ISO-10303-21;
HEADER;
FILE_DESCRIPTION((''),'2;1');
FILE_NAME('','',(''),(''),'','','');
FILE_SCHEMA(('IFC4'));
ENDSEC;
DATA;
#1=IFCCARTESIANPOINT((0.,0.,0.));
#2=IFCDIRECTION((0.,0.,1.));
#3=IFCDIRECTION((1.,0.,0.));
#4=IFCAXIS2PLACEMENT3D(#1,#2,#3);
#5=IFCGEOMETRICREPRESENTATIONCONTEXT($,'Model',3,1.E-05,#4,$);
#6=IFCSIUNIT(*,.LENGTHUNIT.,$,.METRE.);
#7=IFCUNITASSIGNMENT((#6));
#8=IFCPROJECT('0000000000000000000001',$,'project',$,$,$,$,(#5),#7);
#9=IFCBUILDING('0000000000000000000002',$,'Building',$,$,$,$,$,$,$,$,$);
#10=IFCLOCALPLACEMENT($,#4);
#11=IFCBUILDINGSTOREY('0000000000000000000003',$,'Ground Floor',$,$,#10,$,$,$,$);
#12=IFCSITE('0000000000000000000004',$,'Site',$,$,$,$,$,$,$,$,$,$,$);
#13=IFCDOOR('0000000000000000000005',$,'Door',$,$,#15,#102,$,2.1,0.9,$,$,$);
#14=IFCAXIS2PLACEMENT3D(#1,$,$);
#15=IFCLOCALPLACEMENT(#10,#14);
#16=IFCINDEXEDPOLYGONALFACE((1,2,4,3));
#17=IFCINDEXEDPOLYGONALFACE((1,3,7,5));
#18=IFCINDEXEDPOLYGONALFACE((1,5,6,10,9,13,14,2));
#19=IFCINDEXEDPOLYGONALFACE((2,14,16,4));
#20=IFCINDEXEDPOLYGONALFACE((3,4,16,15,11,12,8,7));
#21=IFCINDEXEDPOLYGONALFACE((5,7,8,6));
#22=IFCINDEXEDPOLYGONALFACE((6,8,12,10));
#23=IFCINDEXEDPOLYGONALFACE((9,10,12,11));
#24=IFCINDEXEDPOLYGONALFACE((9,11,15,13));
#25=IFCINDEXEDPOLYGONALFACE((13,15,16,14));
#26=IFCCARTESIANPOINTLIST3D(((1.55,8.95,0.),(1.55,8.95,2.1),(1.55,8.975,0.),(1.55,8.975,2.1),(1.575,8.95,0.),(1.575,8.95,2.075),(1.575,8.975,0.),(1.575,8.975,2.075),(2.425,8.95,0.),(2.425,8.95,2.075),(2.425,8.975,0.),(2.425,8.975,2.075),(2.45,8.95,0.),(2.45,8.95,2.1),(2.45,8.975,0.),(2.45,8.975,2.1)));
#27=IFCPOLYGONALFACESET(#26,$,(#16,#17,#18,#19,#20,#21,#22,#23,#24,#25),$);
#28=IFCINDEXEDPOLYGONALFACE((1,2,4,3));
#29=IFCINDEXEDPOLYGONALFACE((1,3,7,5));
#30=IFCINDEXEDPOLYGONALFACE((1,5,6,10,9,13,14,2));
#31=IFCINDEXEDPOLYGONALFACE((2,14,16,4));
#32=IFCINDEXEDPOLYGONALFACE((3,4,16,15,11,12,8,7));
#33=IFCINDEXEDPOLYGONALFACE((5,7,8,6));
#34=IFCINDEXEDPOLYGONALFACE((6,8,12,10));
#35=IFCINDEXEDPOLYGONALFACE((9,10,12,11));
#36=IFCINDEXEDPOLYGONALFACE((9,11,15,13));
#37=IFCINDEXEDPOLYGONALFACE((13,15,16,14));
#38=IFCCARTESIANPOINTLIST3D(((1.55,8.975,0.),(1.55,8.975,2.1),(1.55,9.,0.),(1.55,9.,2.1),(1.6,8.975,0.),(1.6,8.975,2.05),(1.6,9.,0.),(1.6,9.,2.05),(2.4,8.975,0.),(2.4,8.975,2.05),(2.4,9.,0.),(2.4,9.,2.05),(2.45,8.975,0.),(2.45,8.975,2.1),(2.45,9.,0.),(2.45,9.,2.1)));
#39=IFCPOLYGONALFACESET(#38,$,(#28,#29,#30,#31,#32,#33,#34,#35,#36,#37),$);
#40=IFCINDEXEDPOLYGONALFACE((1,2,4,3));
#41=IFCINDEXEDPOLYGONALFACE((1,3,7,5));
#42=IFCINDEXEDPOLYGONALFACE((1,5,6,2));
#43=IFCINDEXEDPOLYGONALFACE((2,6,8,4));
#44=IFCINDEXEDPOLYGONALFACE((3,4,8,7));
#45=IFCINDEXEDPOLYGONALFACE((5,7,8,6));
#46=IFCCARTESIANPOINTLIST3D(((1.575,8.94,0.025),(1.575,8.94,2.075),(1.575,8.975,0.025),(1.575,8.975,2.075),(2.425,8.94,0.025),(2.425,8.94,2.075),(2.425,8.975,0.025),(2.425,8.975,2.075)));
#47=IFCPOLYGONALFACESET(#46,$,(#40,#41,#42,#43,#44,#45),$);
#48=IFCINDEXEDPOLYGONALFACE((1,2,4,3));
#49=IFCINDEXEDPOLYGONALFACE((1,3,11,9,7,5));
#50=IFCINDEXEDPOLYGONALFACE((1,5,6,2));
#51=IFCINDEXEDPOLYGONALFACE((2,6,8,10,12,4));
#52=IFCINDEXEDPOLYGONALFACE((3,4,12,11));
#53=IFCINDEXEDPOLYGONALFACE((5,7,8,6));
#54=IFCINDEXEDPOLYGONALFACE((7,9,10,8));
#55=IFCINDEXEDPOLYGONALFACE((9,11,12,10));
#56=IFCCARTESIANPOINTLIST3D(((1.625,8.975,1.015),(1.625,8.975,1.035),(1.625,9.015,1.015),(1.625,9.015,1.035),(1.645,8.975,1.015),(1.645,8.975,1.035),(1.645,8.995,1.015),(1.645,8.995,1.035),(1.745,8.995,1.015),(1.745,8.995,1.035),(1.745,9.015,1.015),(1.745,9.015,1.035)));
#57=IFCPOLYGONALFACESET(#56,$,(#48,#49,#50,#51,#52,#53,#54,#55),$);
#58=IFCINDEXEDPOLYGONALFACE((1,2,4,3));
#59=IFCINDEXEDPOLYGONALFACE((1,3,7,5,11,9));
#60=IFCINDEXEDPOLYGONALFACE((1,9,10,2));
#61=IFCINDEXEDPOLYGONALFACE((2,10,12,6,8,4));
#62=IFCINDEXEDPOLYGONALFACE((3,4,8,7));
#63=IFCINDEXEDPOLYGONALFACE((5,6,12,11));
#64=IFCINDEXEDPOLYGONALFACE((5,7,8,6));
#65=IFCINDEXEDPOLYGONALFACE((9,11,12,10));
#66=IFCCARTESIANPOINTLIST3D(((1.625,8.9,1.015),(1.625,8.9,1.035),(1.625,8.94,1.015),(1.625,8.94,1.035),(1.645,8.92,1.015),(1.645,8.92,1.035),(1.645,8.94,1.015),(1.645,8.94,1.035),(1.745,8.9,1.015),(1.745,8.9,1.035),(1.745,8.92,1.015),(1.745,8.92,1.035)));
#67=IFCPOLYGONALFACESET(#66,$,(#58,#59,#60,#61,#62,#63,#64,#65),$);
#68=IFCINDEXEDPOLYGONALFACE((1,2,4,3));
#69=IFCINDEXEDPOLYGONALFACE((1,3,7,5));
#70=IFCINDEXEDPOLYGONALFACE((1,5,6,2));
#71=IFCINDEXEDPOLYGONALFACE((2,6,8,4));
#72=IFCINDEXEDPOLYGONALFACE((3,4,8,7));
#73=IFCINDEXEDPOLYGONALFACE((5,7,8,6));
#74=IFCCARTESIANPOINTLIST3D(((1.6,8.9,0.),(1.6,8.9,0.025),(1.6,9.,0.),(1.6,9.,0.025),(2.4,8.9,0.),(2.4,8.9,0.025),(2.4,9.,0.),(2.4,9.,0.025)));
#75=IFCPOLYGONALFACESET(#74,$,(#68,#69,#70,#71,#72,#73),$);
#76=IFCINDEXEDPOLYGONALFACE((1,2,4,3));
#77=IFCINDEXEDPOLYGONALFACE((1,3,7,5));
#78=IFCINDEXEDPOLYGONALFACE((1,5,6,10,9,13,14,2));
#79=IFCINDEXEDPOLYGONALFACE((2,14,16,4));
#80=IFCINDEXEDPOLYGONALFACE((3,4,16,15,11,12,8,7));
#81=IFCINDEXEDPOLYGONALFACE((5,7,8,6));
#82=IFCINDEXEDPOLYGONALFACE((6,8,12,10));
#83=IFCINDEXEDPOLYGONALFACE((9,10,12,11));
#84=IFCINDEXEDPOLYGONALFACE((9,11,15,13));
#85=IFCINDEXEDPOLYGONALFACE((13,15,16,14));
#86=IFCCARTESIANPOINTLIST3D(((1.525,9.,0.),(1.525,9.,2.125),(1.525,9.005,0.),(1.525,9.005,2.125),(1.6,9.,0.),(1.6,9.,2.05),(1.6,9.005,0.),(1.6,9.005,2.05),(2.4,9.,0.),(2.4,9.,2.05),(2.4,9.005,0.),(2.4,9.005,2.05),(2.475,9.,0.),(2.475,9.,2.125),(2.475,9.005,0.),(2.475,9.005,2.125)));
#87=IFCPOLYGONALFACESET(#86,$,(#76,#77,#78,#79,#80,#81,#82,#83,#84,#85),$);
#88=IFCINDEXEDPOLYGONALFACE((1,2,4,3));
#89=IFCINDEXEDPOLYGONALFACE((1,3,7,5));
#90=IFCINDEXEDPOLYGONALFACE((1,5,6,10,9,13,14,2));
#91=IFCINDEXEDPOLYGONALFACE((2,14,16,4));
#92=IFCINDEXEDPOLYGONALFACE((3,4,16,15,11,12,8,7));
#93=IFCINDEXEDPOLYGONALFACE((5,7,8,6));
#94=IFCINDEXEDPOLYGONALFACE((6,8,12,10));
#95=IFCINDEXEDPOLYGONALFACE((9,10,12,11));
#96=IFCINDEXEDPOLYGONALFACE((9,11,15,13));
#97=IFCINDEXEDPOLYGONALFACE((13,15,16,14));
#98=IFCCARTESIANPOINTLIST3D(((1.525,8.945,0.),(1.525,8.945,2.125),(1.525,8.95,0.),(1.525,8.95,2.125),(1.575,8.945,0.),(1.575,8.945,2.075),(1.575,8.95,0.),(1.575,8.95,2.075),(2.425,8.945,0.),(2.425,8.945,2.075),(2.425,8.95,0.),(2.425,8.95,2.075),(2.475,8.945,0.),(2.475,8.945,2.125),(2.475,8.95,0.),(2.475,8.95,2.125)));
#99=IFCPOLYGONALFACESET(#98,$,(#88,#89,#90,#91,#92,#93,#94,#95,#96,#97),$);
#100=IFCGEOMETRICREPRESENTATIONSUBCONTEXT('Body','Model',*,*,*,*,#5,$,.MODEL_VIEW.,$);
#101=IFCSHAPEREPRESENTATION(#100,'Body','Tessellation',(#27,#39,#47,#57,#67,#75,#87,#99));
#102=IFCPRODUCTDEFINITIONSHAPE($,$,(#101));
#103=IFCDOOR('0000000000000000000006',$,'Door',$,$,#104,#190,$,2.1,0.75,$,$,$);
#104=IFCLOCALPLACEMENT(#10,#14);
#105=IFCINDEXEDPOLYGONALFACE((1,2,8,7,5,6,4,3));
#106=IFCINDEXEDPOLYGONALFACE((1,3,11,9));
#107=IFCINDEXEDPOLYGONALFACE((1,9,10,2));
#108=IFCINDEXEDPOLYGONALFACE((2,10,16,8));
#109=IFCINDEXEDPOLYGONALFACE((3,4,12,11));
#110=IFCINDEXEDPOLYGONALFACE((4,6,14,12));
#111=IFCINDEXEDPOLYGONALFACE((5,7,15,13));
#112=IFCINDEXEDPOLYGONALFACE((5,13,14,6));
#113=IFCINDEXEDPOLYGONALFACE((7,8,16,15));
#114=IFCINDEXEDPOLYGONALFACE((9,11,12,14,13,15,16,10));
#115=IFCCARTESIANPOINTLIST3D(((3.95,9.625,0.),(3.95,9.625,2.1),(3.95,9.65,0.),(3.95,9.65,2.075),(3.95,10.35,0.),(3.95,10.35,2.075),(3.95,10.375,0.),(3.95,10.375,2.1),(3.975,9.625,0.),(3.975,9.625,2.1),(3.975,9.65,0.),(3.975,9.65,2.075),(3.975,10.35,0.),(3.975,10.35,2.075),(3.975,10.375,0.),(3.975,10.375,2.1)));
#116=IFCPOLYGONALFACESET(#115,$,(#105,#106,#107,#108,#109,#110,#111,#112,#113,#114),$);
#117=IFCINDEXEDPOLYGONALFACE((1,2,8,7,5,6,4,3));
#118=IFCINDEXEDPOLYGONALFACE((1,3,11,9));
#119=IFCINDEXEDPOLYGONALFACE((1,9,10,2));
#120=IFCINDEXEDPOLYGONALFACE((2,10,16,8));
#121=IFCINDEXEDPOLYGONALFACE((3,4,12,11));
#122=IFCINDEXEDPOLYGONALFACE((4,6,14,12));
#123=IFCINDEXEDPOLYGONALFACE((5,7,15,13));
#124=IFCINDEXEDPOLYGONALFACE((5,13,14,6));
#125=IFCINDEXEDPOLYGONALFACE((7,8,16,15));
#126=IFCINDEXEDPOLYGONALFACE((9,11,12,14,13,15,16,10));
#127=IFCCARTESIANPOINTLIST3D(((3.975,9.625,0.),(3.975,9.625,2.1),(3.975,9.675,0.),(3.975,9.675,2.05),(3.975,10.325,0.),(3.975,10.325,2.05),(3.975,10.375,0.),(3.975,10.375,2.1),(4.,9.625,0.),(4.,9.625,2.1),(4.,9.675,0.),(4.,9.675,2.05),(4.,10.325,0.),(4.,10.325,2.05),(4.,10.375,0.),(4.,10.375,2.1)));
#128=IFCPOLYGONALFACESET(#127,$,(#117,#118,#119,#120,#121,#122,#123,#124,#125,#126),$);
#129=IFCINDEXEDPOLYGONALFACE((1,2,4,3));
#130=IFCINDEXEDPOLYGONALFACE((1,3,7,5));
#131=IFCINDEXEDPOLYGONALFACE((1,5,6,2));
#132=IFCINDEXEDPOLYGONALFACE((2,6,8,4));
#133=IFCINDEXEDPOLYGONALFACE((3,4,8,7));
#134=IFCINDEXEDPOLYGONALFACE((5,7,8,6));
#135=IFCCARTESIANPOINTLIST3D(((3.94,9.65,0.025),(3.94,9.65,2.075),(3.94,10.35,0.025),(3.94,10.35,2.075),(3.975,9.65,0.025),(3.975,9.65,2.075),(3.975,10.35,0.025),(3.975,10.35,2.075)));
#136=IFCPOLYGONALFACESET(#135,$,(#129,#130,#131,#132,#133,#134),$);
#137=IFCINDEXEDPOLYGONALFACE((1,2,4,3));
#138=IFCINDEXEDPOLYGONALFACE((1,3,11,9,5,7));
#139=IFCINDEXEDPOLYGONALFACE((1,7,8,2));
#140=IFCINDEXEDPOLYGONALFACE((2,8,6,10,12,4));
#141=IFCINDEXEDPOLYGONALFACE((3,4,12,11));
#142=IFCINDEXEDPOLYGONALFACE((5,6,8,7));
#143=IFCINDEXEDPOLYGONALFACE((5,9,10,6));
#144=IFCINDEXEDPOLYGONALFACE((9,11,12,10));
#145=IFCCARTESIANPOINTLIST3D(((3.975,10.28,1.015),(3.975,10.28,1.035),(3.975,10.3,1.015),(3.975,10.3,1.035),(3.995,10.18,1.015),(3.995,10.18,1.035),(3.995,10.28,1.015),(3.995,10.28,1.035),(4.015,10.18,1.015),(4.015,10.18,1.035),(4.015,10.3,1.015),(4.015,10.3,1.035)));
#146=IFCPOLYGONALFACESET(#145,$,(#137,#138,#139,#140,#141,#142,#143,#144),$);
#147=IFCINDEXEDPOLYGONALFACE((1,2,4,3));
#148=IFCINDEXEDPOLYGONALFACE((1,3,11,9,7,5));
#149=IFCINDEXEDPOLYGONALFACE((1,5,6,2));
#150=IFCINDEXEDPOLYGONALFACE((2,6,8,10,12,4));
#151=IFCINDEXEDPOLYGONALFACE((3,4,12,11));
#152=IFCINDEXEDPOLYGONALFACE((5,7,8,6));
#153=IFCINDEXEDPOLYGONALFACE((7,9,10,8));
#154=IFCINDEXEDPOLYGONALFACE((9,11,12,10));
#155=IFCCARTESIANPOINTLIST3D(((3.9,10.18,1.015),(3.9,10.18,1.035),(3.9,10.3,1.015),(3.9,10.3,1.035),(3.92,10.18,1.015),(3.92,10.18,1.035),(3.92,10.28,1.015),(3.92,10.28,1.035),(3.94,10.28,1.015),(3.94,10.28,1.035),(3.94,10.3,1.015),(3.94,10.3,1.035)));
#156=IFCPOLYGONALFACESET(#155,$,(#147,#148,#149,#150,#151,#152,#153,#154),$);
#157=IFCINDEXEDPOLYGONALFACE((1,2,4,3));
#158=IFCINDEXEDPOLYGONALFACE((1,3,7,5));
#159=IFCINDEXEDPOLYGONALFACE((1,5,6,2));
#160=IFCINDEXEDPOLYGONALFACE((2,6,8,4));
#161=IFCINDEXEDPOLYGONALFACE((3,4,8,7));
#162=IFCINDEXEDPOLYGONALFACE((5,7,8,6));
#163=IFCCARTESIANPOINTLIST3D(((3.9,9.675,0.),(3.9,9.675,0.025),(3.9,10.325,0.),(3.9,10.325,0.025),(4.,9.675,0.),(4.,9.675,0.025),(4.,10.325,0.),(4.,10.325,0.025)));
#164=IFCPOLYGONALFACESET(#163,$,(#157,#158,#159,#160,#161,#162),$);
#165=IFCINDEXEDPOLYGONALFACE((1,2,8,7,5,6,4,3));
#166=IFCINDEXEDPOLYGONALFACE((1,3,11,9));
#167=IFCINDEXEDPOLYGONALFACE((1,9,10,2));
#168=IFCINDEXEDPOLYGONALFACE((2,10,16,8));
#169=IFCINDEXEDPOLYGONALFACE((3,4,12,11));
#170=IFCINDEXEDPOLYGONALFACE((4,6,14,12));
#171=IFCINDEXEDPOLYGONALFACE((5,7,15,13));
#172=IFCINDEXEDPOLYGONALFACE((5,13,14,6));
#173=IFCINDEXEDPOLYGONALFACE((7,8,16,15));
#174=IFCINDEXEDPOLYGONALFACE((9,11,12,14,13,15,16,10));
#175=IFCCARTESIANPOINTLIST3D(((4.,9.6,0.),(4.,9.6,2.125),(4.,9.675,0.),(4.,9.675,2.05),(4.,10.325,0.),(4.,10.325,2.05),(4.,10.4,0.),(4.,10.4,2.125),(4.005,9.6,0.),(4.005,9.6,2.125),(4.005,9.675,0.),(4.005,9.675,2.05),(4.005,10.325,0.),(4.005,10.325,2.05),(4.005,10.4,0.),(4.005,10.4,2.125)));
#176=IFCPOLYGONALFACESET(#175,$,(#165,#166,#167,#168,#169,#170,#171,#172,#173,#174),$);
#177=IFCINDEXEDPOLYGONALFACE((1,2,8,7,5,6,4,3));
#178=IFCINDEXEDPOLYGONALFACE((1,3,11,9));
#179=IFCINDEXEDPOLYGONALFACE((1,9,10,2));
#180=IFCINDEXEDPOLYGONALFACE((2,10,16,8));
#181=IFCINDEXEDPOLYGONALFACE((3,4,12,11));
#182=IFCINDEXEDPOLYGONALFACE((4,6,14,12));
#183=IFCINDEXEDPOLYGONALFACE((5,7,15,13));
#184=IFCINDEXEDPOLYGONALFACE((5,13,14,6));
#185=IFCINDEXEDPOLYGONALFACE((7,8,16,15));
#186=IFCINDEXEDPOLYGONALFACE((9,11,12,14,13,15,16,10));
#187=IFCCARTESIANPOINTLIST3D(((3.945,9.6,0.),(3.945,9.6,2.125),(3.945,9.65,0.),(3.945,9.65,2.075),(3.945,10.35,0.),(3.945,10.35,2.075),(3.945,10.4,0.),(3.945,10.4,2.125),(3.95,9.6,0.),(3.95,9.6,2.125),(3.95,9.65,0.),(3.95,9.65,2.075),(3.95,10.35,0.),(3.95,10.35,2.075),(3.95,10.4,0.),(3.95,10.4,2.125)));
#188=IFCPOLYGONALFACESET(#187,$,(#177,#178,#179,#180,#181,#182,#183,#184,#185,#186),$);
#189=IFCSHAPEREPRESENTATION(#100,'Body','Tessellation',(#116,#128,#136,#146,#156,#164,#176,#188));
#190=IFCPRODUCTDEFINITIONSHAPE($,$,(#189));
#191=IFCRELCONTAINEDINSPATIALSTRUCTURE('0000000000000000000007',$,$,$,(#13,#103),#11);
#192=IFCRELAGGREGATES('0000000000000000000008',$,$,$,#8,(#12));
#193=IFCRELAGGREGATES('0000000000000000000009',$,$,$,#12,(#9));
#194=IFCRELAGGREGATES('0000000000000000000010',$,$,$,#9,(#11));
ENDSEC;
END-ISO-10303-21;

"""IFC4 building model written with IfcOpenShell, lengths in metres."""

from ifc_helpers import new_model, si_unit, frame, origin_with_axes, place, context, subcontext, project, spatial, line, indexed_curve, outline, extrude, element, save


model = new_model("IFC4")

# Units and contexts
model_context = context("Model", 3, precision=1e-05, world=origin_with_axes())
body_context = subcontext(model_context, "Body", "Model", "MODEL_VIEW")
ifc_project = project(units=[si_unit("LENGTHUNIT", "METRE")], contexts=[model_context])

# Site, building, storey
site = spatial("IfcSite", under=ifc_project, Name="Site")
building = spatial("IfcBuilding", under=site, Name="Building")
storey_placement = place(None, origin_with_axes())
storey = spatial("IfcBuildingStorey", under=building, at=storey_placement, Name="Ground Floor")

# Doors
door_1_placement = place(storey_placement, frame((2.45, 9.0, 0.0), z_axis=(0.0, 0.0, 1.0), x_axis=(-1.0, 0.0, 0.0)))
element("IfcDoor", 1, at=door_1_placement, inside=storey, Name="Door", OverallHeight=2.1, OverallWidth=0.9, context=body_context, shape_type="SweptSolid", body=[
    extrude(outline(indexed_curve([(0.0, 0.0), (0.0, 2.1), (0.9, 2.1), (0.9, 0.0), (0.875, 0.0), (0.875, 2.075), (0.025, 2.075), (0.025, 0.0)], segments=[line(1, 2, 3, 4, 5, 6, 7, 8, 1)])), frame((0.0, 0.025, 0.0), z_axis=(0.0, -1.0, 0.0), x_axis=(1.0, 0.0, 0.0)), (0.0, 0.0, -1.0), 0.025),
    extrude(outline(indexed_curve([(0.0, 0.0), (0.0, 2.1), (0.9, 2.1), (0.9, 0.0), (0.85, 0.0), (0.85, 2.05), (0.05, 2.05), (0.05, 0.0)], segments=[line(1, 2, 3, 4, 5, 6, 7, 8, 1)])), frame((0.0, 0.0, 0.0), z_axis=(0.0, -1.0, 0.0), x_axis=(1.0, 0.0, 0.0)), (0.0, 0.0, -1.0), 0.025),
    extrude(outline(indexed_curve([(0.0, 0.0), (0.85, 0.0), (0.85, 0.035), (0.0, 0.035)], segments=[line(1, 2, 3, 4, 1)])), frame((0.025, 0.025, 0.025), z_axis=(0.0, 0.0, 1.0), x_axis=(1.0, 0.0, 0.0)), (0.0, 0.0, 1.0), 2.05),
    extrude(outline(indexed_curve([(0.0, 0.0), (0.0, -0.04), (-0.12, -0.04), (-0.12, -0.02), (-0.02, -0.02), (-0.02, 0.0)], segments=[line(1, 2, 3, 4, 5, 6, 1)])), frame((0.825, 0.025, 1.015), z_axis=(0.0, 0.0, 1.0), x_axis=(1.0, 0.0, 0.0)), (0.0, 0.0, 1.0), 0.02),
    extrude(outline(indexed_curve([(0.0, 0.0), (0.0, 0.04), (-0.12, 0.04), (-0.12, 0.02), (-0.02, 0.02), (-0.02, 0.0)], segments=[line(1, 2, 3, 4, 5, 6, 1)])), frame((0.825, 0.06, 1.015), z_axis=(0.0, 0.0, 1.0), x_axis=(1.0, 0.0, 0.0)), (0.0, 0.0, 1.0), 0.02),
    extrude(outline(indexed_curve([(0.0, 0.0), (0.8, 0.0), (0.8, 0.1), (0.0, 0.1)], segments=[line(1, 2, 3, 4, 1)])), frame((0.05, 0.0, 0.0), z_axis=(0.0, 0.0, 1.0), x_axis=(1.0, 0.0, 0.0)), (0.0, 0.0, 1.0), 0.025),
    extrude(outline(indexed_curve([(0.0, 0.0), (0.0, 2.125), (0.95, 2.125), (0.95, 0.0), (0.875, 0.0), (0.875, 2.05), (0.075, 2.05), (0.075, 0.0)], segments=[line(1, 2, 3, 4, 5, 6, 7, 8, 1)])), frame((-0.025, -0.005, 0.0), z_axis=(0.0, -1.0, 0.0), x_axis=(1.0, 0.0, 0.0)), (0.0, 0.0, -1.0), 0.005),
    extrude(outline(indexed_curve([(0.0, 0.0), (0.0, 2.125), (0.95, 2.125), (0.95, 0.0), (0.9, 0.0), (0.9, 2.075), (0.05, 2.075), (0.05, 0.0)], segments=[line(1, 2, 3, 4, 5, 6, 7, 8, 1)])), frame((-0.025, 0.05, 0.0), z_axis=(0.0, -1.0, 0.0), x_axis=(1.0, 0.0, 0.0)), (0.0, 0.0, -1.0), 0.005),
])
door_2_placement = place(storey_placement, frame((4.0, 9.625, 0.0), z_axis=(0.0, 0.0, 1.0), x_axis=(0.0, 1.0, 0.0)))
element("IfcDoor", 2, at=door_2_placement, inside=storey, Name="Door", OverallHeight=2.1, OverallWidth=0.75, context=body_context, shape_type="SweptSolid", body=[
    extrude(outline(indexed_curve([(0.0, 0.0), (0.0, 2.1), (0.75, 2.1), (0.75, 0.0), (0.725, 0.0), (0.725, 2.075), (0.025, 2.075), (0.025, 0.0)], segments=[line(1, 2, 3, 4, 5, 6, 7, 8, 1)])), frame((0.0, 0.025, 0.0), z_axis=(0.0, -1.0, 0.0), x_axis=(1.0, 0.0, 0.0)), (0.0, 0.0, -1.0), 0.025),
    extrude(outline(indexed_curve([(0.0, 0.0), (0.0, 2.1), (0.75, 2.1), (0.75, 0.0), (0.7, 0.0), (0.7, 2.05), (0.05, 2.05), (0.05, 0.0)], segments=[line(1, 2, 3, 4, 5, 6, 7, 8, 1)])), frame((0.0, 0.0, 0.0), z_axis=(0.0, -1.0, 0.0), x_axis=(1.0, 0.0, 0.0)), (0.0, 0.0, -1.0), 0.025),
    extrude(outline(indexed_curve([(0.0, 0.0), (0.7, 0.0), (0.7, 0.035), (0.0, 0.035)], segments=[line(1, 2, 3, 4, 1)])), frame((0.025, 0.025, 0.025), z_axis=(0.0, 0.0, 1.0), x_axis=(1.0, 0.0, 0.0)), (0.0, 0.0, 1.0), 2.05),
    extrude(outline(indexed_curve([(0.0, 0.0), (0.0, -0.04), (-0.12, -0.04), (-0.12, -0.02), (-0.02, -0.02), (-0.02, 0.0)], segments=[line(1, 2, 3, 4, 5, 6, 1)])), frame((0.675, 0.025, 1.015), z_axis=(0.0, 0.0, 1.0), x_axis=(1.0, 0.0, 0.0)), (0.0, 0.0, 1.0), 0.02),
    extrude(outline(indexed_curve([(0.0, 0.0), (0.0, 0.04), (-0.12, 0.04), (-0.12, 0.02), (-0.02, 0.02), (-0.02, 0.0)], segments=[line(1, 2, 3, 4, 5, 6, 1)])), frame((0.675, 0.06, 1.015), z_axis=(0.0, 0.0, 1.0), x_axis=(1.0, 0.0, 0.0)), (0.0, 0.0, 1.0), 0.02),
    extrude(outline(indexed_curve([(0.0, 0.0), (0.65, 0.0), (0.65, 0.1), (0.0, 0.1)], segments=[line(1, 2, 3, 4, 1)])), frame((0.05, 0.0, 0.0), z_axis=(0.0, 0.0, 1.0), x_axis=(1.0, 0.0, 0.0)), (0.0, 0.0, 1.0), 0.025),
    extrude(outline(indexed_curve([(0.0, 0.0), (0.0, 2.125), (0.8, 2.125), (0.8, 0.0), (0.725, 0.0), (0.725, 2.05), (0.075, 2.05), (0.075, 0.0)], segments=[line(1, 2, 3, 4, 5, 6, 7, 8, 1)])), frame((-0.025, -0.005, 0.0), z_axis=(0.0, -1.0, 0.0), x_axis=(1.0, 0.0, 0.0)), (0.0, 0.0, -1.0), 0.005),
    extrude(outline(indexed_curve([(0.0, 0.0), (0.0, 2.125), (0.8, 2.125), (0.8, 0.0), (0.75, 0.0), (0.75, 2.075), (0.05, 2.075), (0.05, 0.0)], segments=[line(1, 2, 3, 4, 5, 6, 7, 8, 1)])), frame((-0.025, 0.05, 0.0), z_axis=(0.0, -1.0, 0.0), x_axis=(1.0, 0.0, 0.0)), (0.0, 0.0, -1.0), 0.005),
])

save(model, "model.ifc")
